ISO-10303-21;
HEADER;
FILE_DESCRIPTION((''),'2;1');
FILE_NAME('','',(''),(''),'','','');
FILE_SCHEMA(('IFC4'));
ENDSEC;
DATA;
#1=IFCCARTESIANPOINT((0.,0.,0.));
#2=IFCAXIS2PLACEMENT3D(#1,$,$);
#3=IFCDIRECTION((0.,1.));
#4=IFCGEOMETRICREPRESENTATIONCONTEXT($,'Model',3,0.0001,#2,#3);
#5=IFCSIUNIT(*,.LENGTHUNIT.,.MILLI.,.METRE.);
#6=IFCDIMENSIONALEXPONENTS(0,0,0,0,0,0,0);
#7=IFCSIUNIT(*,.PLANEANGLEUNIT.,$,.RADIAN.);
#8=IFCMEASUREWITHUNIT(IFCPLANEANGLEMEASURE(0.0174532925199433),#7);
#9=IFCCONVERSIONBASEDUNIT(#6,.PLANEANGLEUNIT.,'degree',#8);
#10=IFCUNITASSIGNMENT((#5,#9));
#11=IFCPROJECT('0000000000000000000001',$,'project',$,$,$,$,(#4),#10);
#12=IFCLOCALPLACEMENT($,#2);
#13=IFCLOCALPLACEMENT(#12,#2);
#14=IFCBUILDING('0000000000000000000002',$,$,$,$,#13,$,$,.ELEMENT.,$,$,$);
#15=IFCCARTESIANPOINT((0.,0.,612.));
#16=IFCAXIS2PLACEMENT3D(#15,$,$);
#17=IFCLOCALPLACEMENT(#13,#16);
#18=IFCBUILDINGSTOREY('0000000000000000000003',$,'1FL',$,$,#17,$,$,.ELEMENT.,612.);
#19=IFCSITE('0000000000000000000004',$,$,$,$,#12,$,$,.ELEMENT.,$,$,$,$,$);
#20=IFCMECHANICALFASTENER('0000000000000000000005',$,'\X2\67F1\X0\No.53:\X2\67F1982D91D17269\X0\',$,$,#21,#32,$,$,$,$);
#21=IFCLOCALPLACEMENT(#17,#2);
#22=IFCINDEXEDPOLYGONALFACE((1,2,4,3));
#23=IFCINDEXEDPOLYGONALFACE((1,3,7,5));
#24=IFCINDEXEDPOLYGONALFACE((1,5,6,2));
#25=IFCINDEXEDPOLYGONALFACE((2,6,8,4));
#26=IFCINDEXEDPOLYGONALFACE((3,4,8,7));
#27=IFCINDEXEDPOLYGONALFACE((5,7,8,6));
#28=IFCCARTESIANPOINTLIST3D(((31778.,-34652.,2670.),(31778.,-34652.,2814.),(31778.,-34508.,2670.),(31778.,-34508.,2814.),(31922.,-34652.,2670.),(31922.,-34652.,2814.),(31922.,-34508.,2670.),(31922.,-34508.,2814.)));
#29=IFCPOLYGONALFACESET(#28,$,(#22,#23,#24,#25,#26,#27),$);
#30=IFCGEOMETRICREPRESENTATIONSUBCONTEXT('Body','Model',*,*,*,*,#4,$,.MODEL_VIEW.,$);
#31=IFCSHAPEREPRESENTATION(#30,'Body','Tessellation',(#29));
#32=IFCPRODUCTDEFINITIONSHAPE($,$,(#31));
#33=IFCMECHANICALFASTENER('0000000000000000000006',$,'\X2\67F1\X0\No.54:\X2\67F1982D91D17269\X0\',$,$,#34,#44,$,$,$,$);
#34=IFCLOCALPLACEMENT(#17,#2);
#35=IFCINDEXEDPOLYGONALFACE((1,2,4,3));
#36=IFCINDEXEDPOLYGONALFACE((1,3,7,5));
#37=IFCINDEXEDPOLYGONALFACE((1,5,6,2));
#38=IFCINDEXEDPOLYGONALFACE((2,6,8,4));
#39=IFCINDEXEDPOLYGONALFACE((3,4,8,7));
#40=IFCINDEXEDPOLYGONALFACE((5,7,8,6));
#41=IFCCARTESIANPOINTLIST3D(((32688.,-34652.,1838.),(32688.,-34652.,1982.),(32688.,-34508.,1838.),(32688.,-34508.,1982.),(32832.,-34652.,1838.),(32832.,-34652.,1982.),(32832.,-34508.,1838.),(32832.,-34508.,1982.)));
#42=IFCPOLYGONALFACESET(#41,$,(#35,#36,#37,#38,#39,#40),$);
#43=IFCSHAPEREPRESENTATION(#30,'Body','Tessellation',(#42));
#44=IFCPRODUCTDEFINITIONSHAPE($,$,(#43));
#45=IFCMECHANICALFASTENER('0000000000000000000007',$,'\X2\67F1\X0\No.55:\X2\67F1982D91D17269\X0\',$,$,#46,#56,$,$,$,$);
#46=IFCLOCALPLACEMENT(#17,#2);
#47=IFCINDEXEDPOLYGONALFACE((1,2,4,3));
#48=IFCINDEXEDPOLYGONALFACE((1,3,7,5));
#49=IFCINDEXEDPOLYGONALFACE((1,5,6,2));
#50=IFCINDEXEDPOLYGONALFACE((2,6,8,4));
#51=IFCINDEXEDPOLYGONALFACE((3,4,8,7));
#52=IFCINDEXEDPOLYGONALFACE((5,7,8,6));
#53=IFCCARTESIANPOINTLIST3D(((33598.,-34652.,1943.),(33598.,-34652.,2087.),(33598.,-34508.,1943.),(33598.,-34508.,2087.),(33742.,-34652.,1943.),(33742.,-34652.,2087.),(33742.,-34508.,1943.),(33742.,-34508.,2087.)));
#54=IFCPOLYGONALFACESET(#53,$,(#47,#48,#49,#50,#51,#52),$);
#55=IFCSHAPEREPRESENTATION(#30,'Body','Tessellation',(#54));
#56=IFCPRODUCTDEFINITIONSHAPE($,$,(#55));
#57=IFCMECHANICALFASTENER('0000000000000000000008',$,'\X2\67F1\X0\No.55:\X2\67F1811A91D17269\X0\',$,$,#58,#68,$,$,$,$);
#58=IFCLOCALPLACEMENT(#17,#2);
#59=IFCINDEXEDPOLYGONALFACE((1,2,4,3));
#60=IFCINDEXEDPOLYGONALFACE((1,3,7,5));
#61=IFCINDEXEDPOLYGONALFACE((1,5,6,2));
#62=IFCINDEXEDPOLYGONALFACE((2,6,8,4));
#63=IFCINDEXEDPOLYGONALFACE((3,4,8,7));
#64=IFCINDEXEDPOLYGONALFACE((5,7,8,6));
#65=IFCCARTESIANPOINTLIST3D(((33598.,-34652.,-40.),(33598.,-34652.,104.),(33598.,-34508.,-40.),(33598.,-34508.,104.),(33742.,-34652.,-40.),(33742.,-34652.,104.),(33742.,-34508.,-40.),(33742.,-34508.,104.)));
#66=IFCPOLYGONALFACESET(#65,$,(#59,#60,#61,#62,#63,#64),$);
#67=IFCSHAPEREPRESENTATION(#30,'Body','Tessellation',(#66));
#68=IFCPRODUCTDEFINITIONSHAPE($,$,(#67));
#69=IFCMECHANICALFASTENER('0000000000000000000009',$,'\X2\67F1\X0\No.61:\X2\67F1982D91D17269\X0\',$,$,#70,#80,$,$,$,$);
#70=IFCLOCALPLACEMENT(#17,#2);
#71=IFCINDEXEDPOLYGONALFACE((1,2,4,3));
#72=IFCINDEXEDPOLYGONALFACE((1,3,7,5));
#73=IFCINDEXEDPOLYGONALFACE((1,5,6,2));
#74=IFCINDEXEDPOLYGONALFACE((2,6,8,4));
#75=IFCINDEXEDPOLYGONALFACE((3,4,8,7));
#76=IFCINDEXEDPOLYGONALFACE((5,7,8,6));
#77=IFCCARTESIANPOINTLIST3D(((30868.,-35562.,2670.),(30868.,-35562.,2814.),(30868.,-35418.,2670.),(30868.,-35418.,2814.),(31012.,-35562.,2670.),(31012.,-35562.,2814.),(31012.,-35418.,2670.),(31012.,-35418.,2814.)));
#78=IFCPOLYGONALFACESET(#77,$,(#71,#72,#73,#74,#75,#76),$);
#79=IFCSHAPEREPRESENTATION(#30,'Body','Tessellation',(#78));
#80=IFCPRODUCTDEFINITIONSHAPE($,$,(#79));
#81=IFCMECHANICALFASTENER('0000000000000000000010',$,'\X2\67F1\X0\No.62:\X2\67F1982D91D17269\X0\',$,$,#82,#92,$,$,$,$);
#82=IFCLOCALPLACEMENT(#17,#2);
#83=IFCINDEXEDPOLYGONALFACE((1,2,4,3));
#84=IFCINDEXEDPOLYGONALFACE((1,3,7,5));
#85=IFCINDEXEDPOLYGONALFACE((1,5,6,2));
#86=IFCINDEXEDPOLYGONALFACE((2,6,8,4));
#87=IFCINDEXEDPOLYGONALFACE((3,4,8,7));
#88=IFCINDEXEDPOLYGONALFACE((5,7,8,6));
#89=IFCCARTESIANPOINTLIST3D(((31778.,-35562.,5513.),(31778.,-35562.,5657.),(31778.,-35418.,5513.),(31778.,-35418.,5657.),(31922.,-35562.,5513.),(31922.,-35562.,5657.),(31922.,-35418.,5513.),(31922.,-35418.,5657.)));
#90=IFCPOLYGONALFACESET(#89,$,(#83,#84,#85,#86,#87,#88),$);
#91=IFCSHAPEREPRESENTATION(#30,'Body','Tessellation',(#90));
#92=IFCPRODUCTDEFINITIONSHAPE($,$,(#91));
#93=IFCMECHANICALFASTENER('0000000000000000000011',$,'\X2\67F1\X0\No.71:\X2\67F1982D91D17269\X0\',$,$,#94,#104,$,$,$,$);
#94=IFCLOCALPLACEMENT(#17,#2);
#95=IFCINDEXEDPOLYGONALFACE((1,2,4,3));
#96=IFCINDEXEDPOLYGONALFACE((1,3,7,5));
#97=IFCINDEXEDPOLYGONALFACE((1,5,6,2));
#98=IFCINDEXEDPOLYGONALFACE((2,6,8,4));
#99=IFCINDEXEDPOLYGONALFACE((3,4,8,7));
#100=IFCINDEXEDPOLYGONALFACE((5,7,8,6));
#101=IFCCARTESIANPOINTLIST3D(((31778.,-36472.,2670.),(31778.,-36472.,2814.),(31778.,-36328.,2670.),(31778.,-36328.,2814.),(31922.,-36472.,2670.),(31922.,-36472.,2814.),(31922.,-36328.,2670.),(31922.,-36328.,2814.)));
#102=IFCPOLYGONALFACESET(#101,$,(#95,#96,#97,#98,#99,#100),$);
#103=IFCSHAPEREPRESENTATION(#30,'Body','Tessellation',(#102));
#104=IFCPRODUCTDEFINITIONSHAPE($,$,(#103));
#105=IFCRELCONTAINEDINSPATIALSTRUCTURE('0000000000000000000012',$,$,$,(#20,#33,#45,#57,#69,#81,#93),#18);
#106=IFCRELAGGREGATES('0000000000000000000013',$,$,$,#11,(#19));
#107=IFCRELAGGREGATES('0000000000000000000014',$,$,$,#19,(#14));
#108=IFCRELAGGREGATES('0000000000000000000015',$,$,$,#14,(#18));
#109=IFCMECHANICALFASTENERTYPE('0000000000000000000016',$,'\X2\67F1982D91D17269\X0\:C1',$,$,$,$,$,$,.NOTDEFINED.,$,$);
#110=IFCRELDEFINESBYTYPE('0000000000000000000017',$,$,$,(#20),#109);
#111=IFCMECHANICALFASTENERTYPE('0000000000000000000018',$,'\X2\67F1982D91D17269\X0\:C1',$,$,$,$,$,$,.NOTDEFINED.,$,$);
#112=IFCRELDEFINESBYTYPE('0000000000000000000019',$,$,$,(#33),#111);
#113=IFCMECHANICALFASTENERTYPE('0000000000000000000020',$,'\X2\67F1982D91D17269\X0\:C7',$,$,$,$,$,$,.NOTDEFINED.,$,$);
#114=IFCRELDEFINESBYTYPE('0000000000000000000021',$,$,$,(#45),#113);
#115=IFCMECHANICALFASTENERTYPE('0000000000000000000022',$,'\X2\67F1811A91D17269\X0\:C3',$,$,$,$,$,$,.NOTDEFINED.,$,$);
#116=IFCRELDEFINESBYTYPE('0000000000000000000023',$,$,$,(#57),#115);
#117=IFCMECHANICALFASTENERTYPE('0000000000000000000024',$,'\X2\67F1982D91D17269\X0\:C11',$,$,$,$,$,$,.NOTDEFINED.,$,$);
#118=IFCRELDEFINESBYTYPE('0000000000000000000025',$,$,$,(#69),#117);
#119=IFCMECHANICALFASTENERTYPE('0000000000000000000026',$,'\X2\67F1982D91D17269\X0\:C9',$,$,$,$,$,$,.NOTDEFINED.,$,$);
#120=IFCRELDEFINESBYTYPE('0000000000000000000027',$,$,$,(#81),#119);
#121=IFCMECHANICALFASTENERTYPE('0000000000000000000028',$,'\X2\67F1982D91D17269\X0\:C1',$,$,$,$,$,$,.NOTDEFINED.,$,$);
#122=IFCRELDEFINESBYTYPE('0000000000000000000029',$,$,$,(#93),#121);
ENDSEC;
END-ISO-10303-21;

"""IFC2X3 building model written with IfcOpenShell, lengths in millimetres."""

from ifc_helpers import new_model, entity, si_unit, converted_unit, direction, frame, origin, origin_with_axes, origin_2d, place, context, subcontext, project, spatial, rectangle, extrude, type_object, element, save


model = new_model("IFC2X3")

# Units and contexts
model_context = context("Model", 3, precision=0.0001, world=origin(), true_north=direction((0.0, 1.0)))
body_context = subcontext(model_context, "Body", "Model", "MODEL_VIEW")
ifc_project = project(units=[si_unit("LENGTHUNIT", "METRE", prefix="MILLI"), converted_unit("PLANEANGLEUNIT", "degree", entity("IfcPlaneAngleMeasure", 0.0174532925199433), si_unit("PLANEANGLEUNIT", "RADIAN"), dimensions=[0, 0, 0, 0, 0, 0, 0])], contexts=[model_context])

# Site, building, storey
site_placement = place(None, origin())
site = spatial("IfcSite", under=ifc_project, at=site_placement, CompositionType="ELEMENT")
building_placement = place(site_placement, origin())
building = spatial("IfcBuilding", under=site, at=building_placement, CompositionType="ELEMENT")
storey_placement = place(building_placement, frame((0.0, 0.0, 612.0)))
storey = spatial("IfcBuildingStorey", under=building, at=storey_placement, Name="1FL", CompositionType="ELEMENT", Elevation=612.0)

# Mechanical fasteners
mechanical_fastener_type_1 = type_object("IfcMechanicalFastenerType", Name="柱頭金物:C1")
mechanical_fastener_1_placement = place(storey_placement, frame((31850.0, -34580.0, 2670.0)))
element("IfcMechanicalFastener", 1, at=mechanical_fastener_1_placement, inside=storey, type_object=mechanical_fastener_type_1, Name="柱No.53:柱頭金物", context=body_context, shape_type="SweptSolid", body=[
    extrude(rectangle(XDim=144.0, YDim=144.0, at=origin_2d()), origin_with_axes(), (0.0, 0.0, 1.0), 144.0),
])
mechanical_fastener_type_2 = type_object("IfcMechanicalFastenerType", Name="柱頭金物:C1")
mechanical_fastener_2_placement = place(storey_placement, frame((32760.0, -34580.0, 1838.0)))
element("IfcMechanicalFastener", 2, at=mechanical_fastener_2_placement, inside=storey, type_object=mechanical_fastener_type_2, Name="柱No.54:柱頭金物", context=body_context, shape_type="SweptSolid", body=[
    extrude(rectangle(XDim=144.0, YDim=144.0, at=origin_2d()), origin_with_axes(), (0.0, 0.0, 1.0), 144.0),
])
mechanical_fastener_type_3 = type_object("IfcMechanicalFastenerType", Name="柱頭金物:C7")
mechanical_fastener_3_placement = place(storey_placement, frame((33670.0, -34580.0, 1943.0)))
element("IfcMechanicalFastener", 3, at=mechanical_fastener_3_placement, inside=storey, type_object=mechanical_fastener_type_3, Name="柱No.55:柱頭金物", context=body_context, shape_type="SweptSolid", body=[
    extrude(rectangle(XDim=144.0, YDim=144.0, at=origin_2d()), origin_with_axes(), (0.0, 0.0, 1.0), 144.0),
])
mechanical_fastener_type_4 = type_object("IfcMechanicalFastenerType", Name="柱脚金物:C3")
mechanical_fastener_4_placement = place(storey_placement, frame((33670.0, -34580.0, -40.0)))
element("IfcMechanicalFastener", 4, at=mechanical_fastener_4_placement, inside=storey, type_object=mechanical_fastener_type_4, Name="柱No.55:柱脚金物", context=body_context, shape_type="SweptSolid", body=[
    extrude(rectangle(XDim=144.0, YDim=144.0, at=origin_2d()), origin_with_axes(), (0.0, 0.0, 1.0), 144.0),
])
mechanical_fastener_type_5 = type_object("IfcMechanicalFastenerType", Name="柱頭金物:C11")
mechanical_fastener_5_placement = place(storey_placement, frame((30940.0, -35490.0, 2670.0)))
element("IfcMechanicalFastener", 5, at=mechanical_fastener_5_placement, inside=storey, type_object=mechanical_fastener_type_5, Name="柱No.61:柱頭金物", context=body_context, shape_type="SweptSolid", body=[
    extrude(rectangle(XDim=144.0, YDim=144.0, at=origin_2d()), origin_with_axes(), (0.0, 0.0, 1.0), 144.0),
])
mechanical_fastener_type_6 = type_object("IfcMechanicalFastenerType", Name="柱頭金物:C9")
mechanical_fastener_6_placement = place(storey_placement, frame((31850.0, -35490.0, 5513.0)))
element("IfcMechanicalFastener", 6, at=mechanical_fastener_6_placement, inside=storey, type_object=mechanical_fastener_type_6, Name="柱No.62:柱頭金物", context=body_context, shape_type="SweptSolid", body=[
    extrude(rectangle(XDim=144.0, YDim=144.0, at=origin_2d()), origin_with_axes(), (0.0, 0.0, 1.0), 144.0),
])
mechanical_fastener_type_7 = type_object("IfcMechanicalFastenerType", Name="柱頭金物:C1")
mechanical_fastener_7_placement = place(storey_placement, frame((31850.0, -36400.0, 2670.0)))
element("IfcMechanicalFastener", 7, at=mechanical_fastener_7_placement, inside=storey, type_object=mechanical_fastener_type_7, Name="柱No.71:柱頭金物", context=body_context, shape_type="SweptSolid", body=[
    extrude(rectangle(XDim=144.0, YDim=144.0, at=origin_2d()), origin_with_axes(), (0.0, 0.0, 1.0), 144.0),
])

save(model, "model.ifc")
